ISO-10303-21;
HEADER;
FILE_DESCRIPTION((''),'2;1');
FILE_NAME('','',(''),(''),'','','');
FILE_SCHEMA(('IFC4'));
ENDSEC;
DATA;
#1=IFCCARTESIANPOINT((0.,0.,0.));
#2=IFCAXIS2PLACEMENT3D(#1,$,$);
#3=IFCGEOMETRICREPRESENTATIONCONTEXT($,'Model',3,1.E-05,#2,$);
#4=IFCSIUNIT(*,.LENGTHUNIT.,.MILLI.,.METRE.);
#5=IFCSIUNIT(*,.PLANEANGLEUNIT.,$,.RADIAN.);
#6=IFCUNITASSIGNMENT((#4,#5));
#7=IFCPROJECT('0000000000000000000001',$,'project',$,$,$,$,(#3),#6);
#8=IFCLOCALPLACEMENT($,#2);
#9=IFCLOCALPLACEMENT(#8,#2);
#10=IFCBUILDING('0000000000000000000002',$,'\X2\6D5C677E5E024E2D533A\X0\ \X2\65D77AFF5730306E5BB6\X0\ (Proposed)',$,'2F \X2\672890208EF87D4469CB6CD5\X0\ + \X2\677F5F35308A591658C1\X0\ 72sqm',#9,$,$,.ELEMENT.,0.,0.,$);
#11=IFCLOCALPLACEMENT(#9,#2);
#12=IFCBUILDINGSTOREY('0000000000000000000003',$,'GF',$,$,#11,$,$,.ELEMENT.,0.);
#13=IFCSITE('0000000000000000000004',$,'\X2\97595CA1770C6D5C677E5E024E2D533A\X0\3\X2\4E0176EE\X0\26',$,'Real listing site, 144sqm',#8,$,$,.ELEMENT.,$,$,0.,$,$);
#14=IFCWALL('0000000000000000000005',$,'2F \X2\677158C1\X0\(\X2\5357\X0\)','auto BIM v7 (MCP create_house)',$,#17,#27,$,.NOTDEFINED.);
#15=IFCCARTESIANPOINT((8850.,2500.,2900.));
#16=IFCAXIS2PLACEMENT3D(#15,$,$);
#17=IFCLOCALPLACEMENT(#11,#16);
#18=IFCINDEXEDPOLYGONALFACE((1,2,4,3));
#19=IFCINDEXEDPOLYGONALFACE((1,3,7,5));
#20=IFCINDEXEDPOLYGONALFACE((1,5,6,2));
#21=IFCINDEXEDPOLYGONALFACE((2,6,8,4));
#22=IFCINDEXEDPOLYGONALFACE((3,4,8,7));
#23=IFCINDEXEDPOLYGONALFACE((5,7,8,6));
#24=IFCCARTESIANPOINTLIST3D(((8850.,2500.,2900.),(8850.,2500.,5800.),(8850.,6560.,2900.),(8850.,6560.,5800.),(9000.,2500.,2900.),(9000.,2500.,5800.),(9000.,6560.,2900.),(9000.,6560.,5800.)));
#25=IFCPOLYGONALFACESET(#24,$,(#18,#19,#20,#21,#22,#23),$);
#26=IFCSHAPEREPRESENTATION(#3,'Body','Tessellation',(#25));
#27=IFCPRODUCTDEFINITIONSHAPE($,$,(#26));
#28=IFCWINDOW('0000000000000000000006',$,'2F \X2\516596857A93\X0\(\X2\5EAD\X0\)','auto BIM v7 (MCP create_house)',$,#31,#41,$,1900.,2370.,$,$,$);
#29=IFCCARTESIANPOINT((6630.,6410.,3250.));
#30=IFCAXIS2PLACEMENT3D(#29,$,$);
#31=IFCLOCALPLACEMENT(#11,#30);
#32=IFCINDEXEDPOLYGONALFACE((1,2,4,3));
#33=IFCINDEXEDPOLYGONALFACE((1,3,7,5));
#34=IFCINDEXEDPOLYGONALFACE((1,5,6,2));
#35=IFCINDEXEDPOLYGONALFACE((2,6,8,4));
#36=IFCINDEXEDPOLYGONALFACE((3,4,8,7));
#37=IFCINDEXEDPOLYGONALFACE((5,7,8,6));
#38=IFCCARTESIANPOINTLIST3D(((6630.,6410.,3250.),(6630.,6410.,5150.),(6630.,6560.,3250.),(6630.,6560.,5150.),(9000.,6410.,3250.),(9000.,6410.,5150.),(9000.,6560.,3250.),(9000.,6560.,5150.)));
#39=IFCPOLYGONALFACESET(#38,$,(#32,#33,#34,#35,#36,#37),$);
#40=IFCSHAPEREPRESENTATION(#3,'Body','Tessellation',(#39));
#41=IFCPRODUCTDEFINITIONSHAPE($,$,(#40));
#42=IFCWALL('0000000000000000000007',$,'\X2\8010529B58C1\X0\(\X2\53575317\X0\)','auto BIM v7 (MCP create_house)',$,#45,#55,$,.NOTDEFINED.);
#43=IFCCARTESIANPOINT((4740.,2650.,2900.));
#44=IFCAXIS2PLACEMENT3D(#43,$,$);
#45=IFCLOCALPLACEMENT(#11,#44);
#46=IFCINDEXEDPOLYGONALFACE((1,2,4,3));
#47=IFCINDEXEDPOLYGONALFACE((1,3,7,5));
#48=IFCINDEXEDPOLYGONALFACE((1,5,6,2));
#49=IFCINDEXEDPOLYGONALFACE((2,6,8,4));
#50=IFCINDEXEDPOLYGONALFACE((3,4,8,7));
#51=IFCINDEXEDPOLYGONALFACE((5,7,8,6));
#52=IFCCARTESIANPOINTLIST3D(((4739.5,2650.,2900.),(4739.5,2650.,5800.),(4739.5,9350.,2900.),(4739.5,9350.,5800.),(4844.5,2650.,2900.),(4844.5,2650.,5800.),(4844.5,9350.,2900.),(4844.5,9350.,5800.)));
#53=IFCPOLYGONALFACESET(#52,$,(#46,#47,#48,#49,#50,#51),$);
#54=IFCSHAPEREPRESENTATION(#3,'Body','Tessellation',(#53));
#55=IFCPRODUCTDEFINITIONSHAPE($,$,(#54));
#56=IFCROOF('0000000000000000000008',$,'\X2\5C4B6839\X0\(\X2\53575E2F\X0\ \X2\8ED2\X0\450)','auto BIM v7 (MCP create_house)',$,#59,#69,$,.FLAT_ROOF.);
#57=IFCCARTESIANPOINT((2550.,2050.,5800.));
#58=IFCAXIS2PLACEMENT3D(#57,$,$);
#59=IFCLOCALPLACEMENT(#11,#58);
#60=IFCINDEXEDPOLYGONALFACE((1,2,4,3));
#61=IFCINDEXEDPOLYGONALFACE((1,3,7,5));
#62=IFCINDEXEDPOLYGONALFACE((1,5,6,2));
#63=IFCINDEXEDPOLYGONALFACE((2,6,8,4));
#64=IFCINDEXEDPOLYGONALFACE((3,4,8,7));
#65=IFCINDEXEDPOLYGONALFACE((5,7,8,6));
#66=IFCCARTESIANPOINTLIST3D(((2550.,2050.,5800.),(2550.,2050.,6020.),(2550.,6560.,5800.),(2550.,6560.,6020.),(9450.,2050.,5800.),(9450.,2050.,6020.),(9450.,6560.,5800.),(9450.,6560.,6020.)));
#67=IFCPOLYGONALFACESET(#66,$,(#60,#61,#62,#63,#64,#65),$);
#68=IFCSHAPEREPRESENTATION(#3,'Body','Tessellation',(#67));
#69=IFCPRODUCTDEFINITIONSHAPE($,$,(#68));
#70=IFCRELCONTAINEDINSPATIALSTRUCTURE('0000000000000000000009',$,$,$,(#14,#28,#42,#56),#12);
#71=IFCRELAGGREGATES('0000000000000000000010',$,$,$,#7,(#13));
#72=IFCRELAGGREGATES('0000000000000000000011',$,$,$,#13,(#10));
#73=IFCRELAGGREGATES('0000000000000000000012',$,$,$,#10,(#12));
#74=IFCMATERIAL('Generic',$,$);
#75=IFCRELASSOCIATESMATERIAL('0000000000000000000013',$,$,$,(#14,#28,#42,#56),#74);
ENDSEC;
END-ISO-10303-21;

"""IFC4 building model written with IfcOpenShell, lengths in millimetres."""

from ifc_helpers import new_model, si_unit, frame, frame_2d, origin, place, context, project, spatial, rectangle, extrude, material, element, fill, save


model = new_model("IFC4")

# Units and contexts
model_context = context("Model", 3, precision=1e-05, world=origin())
ifc_project = project(units=[si_unit("LENGTHUNIT", "METRE", prefix="MILLI"), si_unit("PLANEANGLEUNIT", "RADIAN")], contexts=[model_context])

# Site, building, storey
site_placement = place(None, origin())
site = spatial("IfcSite", under=ifc_project, at=site_placement, Name="静岡県浜松市中区3丁目26", ObjectType="Real listing site, 144sqm", CompositionType="ELEMENT", RefElevation=0.0)
building_placement = place(site_placement, origin())
building = spatial("IfcBuilding", under=site, at=building_placement, Name="浜松市中区 旗竿地の家 (Proposed)", ObjectType="2F 木造軸組構法 + 板張り外壁 72sqm", CompositionType="ELEMENT", ElevationOfRefHeight=0.0, ElevationOfTerrain=0.0)
storey_placement = place(building_placement, origin())
storey = spatial("IfcBuildingStorey", under=building, at=storey_placement, Name="GF", CompositionType="ELEMENT", Elevation=0.0)

# Shared definitions
ifc_material = material(Name="Generic")

# Wall, opening, window
wall_1_placement = place(storey_placement, frame((8850.0, 2500.0, 2900.0)))
wall_1 = element("IfcWall", 1, at=wall_1_placement, inside=storey, material=ifc_material, Name="2F 東壁(南)", Description="auto BIM v7 (MCP create_house)", PredefinedType="NOTDEFINED", context=model_context, shape_type="SweptSolid", body=[
    extrude(rectangle(XDim=150.0, YDim=4060.0, at=frame_2d((75.0, 2030.0))), frame((8850.0, 2500.0, 2900.0)), (0.0, 0.0, 1.0), 2900.0),
])
opening_1_placement = place(storey_placement, frame((6630.0, 6410.0, 3250.0)))
opening_1 = element("IfcOpeningElement", 2, at=opening_1_placement, cuts=wall_1, PredefinedType="NOTDEFINED", context=model_context, shape_type="SweptSolid", body=[
    extrude(rectangle(XDim=2370.0, YDim=150.0, at=frame_2d((1185.0, 75.0))), frame((6630.0, 6410.0, 3250.0)), (0.0, 0.0, 1.0), 1900.0),
])
window_1_placement = place(storey_placement, frame((6630.0, 6410.0, 3250.0)))
window_1 = element("IfcWindow", 3, at=window_1_placement, inside=storey, material=ifc_material, Name="2F 入隅窓(庭)", Description="auto BIM v7 (MCP create_house)", OverallHeight=1900.0, OverallWidth=2370.0, context=model_context, shape_type="SweptSolid", body=[
    extrude(rectangle(XDim=2370.0, YDim=150.0, at=frame_2d((1185.0, 75.0))), frame((6630.0, 6410.0, 3250.0)), (0.0, 0.0, 1.0), 1900.0),
])
fill(opening_1, window_1)

# Wall
wall_2_placement = place(storey_placement, frame((4740.0, 2650.0, 2900.0)))
element("IfcWall", 4, at=wall_2_placement, inside=storey, material=ifc_material, Name="耐力壁(南北)", Description="auto BIM v7 (MCP create_house)", PredefinedType="NOTDEFINED", context=model_context, shape_type="SweptSolid", body=[
    extrude(rectangle(XDim=105.0, YDim=6700.0, at=frame_2d((52.0, 3350.0))), frame((4740.0, 2650.0, 2900.0)), (0.0, 0.0, 1.0), 2900.0),
])

# Roof
for number, where, name in (
    (5, (2550.0, 2050.0, 5800.0), "屋根(南帯 軒450)"),
):
    element("IfcRoof", number, at=place(storey_placement, frame(where)), inside=storey, material=ifc_material, Name=name, Description="auto BIM v7 (MCP create_house)", PredefinedType="FLAT_ROOF", context=model_context, shape_type="SweptSolid", body=[
        extrude(rectangle(XDim=6900.0, YDim=4510.0, at=frame_2d((3450.0, 2255.0))), frame((2550.0, 2050.0, 5800.0)), (0.0, 0.0, 1.0), 220.0),
    ])

save(model, "model.ifc")
